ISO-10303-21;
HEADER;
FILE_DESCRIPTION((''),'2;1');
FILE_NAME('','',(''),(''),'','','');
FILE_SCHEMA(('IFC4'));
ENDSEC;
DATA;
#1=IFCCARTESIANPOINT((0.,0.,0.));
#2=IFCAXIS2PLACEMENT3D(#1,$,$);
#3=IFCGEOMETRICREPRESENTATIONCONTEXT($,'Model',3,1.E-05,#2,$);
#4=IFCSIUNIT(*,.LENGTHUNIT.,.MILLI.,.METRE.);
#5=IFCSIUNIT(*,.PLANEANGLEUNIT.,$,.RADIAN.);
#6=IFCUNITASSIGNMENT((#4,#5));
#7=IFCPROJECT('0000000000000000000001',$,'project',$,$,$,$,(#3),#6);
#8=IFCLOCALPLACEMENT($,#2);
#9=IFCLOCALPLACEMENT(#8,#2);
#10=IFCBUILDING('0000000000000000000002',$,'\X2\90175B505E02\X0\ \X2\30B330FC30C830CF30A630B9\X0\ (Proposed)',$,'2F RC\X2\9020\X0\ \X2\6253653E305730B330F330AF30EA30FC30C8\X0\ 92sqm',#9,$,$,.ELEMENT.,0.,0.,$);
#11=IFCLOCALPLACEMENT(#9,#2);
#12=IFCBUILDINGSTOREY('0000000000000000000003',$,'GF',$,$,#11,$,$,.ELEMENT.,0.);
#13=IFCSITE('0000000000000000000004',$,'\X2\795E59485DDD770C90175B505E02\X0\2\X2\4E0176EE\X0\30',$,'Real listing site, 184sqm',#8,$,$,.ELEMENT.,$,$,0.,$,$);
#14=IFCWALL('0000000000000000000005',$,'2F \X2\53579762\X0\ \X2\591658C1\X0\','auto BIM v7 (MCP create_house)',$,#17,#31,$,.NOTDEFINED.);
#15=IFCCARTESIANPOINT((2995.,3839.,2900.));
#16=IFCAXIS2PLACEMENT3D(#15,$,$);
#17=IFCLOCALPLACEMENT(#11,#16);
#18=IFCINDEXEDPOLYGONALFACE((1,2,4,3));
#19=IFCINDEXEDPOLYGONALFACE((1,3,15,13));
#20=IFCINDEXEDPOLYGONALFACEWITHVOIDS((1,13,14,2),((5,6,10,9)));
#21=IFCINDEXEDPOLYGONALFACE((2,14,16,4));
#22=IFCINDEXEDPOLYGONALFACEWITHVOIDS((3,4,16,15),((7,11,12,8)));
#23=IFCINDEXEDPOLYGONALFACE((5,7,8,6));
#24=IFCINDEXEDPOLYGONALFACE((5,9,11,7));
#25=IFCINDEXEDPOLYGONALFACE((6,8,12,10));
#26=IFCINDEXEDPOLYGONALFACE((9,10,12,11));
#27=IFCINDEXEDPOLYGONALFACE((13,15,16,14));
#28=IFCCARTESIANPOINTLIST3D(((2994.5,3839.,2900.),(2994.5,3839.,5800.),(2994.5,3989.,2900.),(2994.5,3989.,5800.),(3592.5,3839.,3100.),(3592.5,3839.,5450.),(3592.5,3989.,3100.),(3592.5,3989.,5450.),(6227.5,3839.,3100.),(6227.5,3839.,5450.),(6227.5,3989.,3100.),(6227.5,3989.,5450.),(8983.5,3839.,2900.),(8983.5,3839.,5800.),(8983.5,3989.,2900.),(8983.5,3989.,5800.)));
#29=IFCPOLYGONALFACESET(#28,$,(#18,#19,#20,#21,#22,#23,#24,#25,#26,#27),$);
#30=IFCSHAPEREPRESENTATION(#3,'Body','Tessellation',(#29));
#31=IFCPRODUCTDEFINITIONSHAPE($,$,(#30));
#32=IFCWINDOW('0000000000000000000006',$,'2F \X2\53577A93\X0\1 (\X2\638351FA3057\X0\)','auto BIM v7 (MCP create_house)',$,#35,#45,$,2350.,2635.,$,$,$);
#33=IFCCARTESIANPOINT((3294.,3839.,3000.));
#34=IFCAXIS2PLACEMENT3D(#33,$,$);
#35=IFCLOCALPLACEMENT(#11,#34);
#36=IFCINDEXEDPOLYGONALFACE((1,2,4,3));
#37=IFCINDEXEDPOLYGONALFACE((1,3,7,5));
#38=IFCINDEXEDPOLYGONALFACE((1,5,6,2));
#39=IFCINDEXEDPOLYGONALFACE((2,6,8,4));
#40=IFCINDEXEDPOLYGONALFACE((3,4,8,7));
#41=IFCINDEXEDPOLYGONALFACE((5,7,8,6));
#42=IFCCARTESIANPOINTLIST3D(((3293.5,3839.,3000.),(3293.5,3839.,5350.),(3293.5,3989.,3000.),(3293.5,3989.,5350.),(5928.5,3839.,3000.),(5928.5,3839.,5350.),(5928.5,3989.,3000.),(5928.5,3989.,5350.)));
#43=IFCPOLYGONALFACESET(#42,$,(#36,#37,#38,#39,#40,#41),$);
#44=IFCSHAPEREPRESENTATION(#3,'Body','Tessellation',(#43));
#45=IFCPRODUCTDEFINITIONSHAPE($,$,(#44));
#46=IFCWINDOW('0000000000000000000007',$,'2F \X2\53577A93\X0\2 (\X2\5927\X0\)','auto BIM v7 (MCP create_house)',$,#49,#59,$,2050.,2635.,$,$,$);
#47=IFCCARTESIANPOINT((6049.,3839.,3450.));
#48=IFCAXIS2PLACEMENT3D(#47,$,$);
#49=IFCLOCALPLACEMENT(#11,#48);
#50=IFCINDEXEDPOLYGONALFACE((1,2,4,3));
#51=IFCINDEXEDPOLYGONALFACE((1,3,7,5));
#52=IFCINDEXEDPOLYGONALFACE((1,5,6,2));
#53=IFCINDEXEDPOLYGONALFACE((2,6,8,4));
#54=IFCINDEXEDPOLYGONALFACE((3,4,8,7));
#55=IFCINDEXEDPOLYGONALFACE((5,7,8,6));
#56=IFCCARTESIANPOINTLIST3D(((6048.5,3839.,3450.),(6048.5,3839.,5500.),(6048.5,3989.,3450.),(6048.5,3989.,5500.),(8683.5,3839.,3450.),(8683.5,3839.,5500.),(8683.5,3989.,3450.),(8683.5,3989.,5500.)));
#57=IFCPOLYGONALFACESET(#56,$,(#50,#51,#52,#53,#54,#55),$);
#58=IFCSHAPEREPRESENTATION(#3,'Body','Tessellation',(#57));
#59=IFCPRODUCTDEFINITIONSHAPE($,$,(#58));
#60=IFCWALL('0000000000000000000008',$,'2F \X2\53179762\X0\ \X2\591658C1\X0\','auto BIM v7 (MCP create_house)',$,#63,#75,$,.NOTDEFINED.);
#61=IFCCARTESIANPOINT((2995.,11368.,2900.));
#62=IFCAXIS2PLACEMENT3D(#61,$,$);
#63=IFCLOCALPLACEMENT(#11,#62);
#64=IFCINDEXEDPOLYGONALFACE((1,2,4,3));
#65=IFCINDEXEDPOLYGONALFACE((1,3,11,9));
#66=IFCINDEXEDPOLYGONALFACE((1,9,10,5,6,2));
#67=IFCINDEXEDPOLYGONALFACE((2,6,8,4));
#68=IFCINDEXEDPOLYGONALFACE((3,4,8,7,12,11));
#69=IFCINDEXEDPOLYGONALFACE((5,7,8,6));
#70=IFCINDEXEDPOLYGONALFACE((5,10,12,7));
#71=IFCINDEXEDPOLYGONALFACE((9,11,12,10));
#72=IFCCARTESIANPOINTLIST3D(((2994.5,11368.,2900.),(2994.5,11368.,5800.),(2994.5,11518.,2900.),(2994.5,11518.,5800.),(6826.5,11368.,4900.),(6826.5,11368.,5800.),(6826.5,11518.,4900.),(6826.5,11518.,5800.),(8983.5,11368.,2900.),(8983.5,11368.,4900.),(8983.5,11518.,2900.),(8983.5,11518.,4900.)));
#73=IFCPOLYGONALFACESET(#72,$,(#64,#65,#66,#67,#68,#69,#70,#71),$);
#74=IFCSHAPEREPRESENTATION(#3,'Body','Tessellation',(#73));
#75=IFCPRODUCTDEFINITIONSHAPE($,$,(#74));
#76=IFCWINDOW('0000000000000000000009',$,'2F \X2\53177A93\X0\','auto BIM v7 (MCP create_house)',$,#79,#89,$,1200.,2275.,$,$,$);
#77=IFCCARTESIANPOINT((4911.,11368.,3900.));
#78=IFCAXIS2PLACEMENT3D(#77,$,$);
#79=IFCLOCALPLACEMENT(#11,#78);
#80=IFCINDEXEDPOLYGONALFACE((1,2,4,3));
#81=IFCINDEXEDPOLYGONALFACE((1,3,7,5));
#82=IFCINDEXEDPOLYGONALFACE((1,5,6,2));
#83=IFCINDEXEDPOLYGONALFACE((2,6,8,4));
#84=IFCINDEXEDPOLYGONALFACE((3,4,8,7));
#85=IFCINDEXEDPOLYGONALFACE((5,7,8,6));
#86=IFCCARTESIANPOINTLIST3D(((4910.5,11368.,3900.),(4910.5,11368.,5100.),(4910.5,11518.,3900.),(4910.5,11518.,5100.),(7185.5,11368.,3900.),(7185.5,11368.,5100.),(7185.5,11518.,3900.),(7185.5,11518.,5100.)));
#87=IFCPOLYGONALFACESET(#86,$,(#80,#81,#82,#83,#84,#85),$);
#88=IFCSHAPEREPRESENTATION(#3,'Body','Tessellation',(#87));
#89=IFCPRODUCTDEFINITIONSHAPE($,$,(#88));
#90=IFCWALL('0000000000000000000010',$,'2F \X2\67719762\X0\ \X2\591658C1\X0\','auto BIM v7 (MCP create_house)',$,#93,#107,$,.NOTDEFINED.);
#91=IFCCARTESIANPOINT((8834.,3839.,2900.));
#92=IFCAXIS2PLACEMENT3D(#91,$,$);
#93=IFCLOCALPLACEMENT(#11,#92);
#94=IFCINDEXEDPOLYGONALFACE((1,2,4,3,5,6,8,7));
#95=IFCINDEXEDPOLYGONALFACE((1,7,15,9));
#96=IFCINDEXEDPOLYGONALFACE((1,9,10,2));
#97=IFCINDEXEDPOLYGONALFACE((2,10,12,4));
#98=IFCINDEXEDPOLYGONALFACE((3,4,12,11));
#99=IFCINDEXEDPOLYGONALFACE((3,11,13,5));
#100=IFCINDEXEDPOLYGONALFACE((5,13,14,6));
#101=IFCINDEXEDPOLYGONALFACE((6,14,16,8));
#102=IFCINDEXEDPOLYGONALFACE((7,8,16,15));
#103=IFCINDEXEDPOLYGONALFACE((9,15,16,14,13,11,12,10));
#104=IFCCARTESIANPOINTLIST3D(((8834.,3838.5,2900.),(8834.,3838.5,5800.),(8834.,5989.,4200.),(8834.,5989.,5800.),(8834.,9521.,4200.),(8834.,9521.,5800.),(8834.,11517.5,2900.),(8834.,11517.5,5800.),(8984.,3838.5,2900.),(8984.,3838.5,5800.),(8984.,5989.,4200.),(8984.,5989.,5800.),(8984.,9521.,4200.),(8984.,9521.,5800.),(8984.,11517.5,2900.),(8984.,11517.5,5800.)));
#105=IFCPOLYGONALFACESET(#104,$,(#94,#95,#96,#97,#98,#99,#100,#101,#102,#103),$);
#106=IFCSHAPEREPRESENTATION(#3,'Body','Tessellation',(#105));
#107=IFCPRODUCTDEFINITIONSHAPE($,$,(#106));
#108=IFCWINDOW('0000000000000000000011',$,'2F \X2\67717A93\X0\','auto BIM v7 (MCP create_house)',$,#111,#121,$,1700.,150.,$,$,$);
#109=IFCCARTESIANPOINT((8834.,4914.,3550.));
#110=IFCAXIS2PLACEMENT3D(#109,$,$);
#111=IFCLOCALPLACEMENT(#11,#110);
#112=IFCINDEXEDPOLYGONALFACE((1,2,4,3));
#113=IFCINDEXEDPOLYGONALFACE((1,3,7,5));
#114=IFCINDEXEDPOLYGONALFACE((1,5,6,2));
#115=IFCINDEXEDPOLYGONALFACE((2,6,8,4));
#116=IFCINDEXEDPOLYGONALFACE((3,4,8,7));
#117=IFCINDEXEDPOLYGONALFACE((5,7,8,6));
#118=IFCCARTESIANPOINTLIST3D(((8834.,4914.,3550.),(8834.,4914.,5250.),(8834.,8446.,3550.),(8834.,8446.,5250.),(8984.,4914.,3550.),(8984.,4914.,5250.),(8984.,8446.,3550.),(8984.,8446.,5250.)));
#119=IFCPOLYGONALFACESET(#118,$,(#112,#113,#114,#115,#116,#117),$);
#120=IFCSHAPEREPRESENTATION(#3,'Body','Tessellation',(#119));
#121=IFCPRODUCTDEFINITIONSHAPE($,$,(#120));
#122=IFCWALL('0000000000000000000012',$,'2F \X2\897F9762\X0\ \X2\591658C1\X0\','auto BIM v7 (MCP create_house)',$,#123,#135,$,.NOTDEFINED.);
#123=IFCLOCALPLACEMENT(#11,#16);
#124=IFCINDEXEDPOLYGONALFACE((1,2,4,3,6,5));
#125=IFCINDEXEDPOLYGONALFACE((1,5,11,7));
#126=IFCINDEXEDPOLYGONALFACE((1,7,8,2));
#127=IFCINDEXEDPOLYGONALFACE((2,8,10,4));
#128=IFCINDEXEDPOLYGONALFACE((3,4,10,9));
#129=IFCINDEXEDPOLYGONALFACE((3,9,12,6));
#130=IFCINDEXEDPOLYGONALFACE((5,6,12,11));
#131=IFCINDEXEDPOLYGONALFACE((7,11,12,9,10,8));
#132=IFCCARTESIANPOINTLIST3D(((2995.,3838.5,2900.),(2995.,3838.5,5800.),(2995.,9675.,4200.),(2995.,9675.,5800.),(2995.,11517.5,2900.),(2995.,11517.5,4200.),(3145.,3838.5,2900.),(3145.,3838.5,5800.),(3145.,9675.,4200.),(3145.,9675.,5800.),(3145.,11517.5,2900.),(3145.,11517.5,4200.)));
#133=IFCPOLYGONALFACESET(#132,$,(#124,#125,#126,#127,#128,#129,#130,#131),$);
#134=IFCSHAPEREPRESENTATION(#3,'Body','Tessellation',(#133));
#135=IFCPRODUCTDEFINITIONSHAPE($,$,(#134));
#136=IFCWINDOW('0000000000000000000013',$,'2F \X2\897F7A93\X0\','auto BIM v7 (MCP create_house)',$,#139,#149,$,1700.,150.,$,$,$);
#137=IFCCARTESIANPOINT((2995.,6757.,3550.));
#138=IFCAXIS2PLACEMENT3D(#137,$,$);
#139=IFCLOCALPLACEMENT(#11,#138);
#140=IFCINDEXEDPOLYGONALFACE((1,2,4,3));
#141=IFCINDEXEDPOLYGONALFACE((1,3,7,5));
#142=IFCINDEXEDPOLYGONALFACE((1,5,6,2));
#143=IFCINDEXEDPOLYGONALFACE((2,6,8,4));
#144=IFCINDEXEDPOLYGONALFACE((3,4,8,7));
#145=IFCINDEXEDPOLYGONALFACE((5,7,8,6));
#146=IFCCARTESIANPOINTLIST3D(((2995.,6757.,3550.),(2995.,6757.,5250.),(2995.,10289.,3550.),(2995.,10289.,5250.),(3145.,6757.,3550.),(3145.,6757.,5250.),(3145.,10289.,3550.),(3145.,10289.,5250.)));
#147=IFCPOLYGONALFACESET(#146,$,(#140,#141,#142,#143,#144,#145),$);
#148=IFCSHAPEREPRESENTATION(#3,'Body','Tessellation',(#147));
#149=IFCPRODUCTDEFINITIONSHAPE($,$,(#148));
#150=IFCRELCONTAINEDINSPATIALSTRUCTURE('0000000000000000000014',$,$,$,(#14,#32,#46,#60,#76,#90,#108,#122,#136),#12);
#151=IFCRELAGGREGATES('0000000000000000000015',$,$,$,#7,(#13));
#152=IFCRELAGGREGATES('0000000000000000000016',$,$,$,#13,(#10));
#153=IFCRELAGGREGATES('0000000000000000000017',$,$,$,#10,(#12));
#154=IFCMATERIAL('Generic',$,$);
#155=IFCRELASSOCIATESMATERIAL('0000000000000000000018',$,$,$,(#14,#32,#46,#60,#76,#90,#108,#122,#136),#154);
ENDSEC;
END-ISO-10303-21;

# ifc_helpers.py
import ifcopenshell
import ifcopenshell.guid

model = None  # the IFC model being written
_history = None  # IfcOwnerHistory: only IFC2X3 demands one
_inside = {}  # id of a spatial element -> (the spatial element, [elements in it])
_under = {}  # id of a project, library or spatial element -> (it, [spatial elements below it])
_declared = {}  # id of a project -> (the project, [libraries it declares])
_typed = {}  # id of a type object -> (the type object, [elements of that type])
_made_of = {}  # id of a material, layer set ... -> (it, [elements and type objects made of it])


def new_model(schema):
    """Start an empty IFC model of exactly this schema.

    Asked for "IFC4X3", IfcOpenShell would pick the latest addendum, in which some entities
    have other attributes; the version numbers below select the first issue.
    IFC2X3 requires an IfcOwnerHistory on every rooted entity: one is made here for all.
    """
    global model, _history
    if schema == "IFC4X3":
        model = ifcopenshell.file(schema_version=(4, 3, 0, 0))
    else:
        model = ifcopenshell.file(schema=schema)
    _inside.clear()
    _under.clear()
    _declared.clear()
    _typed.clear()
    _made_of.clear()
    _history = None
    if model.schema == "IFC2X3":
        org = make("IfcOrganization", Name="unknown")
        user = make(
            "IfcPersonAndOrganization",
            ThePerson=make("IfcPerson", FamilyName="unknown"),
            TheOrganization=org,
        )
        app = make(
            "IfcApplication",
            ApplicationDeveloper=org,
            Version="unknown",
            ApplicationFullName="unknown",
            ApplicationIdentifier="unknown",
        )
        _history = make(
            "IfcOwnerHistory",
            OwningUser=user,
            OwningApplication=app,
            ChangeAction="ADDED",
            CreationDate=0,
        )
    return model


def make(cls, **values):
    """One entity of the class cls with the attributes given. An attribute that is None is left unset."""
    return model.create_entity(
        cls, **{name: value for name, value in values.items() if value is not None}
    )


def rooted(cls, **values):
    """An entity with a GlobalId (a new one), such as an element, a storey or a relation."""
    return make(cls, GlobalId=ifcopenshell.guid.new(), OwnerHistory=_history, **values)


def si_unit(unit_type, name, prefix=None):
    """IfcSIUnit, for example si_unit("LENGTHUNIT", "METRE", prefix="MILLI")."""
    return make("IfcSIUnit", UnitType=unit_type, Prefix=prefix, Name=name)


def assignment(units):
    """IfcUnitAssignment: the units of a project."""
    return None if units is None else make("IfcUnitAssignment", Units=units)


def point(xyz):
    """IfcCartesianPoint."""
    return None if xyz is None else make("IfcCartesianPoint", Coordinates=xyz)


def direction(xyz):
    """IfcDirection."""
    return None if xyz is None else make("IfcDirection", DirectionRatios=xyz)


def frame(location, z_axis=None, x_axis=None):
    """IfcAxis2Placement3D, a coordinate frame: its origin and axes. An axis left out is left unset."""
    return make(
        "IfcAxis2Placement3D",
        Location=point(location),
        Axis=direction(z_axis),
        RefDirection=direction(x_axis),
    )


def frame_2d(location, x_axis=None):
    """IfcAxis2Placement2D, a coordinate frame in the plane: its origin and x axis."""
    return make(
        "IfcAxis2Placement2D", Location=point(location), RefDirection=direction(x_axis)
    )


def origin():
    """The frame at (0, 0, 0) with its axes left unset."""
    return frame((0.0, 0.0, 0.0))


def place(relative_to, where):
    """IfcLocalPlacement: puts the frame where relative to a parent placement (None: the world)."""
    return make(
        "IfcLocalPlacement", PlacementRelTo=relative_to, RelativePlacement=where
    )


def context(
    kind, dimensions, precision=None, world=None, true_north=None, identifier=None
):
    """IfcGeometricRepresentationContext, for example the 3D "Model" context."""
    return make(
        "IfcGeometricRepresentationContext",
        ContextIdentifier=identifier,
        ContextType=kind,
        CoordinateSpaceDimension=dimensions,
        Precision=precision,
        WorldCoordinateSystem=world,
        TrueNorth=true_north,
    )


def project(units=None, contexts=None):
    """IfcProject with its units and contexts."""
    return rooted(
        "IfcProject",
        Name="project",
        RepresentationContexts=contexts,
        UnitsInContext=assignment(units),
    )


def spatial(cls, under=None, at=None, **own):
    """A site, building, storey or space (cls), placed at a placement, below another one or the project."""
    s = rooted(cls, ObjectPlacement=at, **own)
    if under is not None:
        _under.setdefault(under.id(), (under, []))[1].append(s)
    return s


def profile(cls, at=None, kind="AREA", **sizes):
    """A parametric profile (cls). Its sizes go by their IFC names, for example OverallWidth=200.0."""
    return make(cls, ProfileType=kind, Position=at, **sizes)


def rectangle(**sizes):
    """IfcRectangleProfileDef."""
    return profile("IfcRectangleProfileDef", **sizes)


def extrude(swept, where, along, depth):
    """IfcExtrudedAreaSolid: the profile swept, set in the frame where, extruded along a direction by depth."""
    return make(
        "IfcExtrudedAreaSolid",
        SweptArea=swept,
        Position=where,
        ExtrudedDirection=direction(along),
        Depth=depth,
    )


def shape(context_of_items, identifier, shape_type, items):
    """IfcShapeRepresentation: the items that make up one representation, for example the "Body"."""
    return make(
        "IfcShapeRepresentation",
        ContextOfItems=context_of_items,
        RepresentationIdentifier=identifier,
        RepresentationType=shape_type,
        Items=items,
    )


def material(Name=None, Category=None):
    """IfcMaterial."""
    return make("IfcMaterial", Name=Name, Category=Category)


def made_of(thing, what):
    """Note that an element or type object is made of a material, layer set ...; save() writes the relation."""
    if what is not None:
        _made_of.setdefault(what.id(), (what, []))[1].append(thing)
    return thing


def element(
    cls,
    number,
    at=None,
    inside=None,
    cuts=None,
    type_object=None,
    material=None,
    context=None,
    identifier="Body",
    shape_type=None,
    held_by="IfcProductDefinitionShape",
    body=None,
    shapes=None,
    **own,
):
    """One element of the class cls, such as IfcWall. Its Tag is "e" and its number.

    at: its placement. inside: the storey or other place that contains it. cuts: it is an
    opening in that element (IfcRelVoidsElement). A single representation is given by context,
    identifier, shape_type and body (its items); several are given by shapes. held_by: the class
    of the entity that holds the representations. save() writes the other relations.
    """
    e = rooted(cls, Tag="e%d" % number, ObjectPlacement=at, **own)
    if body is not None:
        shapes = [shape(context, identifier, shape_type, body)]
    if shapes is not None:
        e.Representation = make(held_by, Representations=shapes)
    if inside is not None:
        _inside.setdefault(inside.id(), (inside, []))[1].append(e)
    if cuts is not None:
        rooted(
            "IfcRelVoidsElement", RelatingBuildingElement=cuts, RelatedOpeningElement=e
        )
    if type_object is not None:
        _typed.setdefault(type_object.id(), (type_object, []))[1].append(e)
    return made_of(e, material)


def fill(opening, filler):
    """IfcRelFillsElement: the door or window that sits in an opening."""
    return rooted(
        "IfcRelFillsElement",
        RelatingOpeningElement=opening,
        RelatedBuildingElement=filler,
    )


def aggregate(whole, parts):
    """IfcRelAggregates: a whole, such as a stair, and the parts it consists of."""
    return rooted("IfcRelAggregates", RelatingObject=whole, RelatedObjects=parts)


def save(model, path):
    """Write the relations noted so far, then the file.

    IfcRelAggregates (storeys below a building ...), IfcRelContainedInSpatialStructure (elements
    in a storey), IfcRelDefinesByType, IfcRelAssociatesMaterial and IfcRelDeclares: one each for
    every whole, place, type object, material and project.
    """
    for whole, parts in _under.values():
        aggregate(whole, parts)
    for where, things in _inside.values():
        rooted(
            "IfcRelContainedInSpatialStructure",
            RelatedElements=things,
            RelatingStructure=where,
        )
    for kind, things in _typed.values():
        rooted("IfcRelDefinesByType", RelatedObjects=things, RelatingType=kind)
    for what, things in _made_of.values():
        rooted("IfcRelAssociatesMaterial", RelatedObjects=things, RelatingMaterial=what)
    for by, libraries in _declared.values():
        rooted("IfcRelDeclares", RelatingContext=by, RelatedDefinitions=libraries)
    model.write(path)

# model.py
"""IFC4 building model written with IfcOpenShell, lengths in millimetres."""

from ifc_helpers import new_model, si_unit, frame, frame_2d, origin, place, context, project, spatial, rectangle, extrude, material, element, fill, save


model = new_model("IFC4")

# Units and contexts
model_context = context("Model", 3, precision=1e-05, world=origin())
ifc_project = project(units=[si_unit("LENGTHUNIT", "METRE", prefix="MILLI"), si_unit("PLANEANGLEUNIT", "RADIAN")], contexts=[model_context])

# Site, building, storey
site_placement = place(None, origin())
site = spatial("IfcSite", under=ifc_project, at=site_placement, Name="神奈川県逗子市2丁目30", ObjectType="Real listing site, 184sqm", CompositionType="ELEMENT", RefElevation=0.0)
building_placement = place(site_placement, origin())
building = spatial("IfcBuilding", under=site, at=building_placement, Name="逗子市 コートハウス (Proposed)", ObjectType="2F RC造 打放しコンクリート 92sqm", CompositionType="ELEMENT", ElevationOfRefHeight=0.0, ElevationOfTerrain=0.0)
storey_placement = place(building_placement, origin())
storey = spatial("IfcBuildingStorey", under=building, at=storey_placement, Name="GF", CompositionType="ELEMENT", Elevation=0.0)

# Shared definitions
ifc_material = material(Name="Generic")

# Wall, openings, windows
wall_1_placement = place(storey_placement, frame((2995.0, 3839.0, 2900.0)))
wall_1 = element("IfcWall", 1, at=wall_1_placement, inside=storey, material=ifc_material, Name="2F 南面 外壁", Description="auto BIM v7 (MCP create_house)", PredefinedType="NOTDEFINED", context=model_context, shape_type="SweptSolid", body=[
    extrude(rectangle(XDim=5989.0, YDim=150.0, at=frame_2d((2994.0, 75.0))), frame((2995.0, 3839.0, 2900.0)), (0.0, 0.0, 1.0), 2900.0),
])
opening_1_placement = place(storey_placement, frame((3294.0, 3839.0, 3000.0)))
opening_1 = element("IfcOpeningElement", 2, at=opening_1_placement, cuts=wall_1, PredefinedType="NOTDEFINED", context=model_context, shape_type="SweptSolid", body=[
    extrude(rectangle(XDim=2635.0, YDim=150.0, at=frame_2d((1317.0, 75.0))), frame((3294.0, 3839.0, 3000.0)), (0.0, 0.0, 1.0), 2350.0),
])
opening_2_placement = place(storey_placement, frame((6049.0, 3839.0, 3450.0)))
opening_2 = element("IfcOpeningElement", 3, at=opening_2_placement, cuts=wall_1, PredefinedType="NOTDEFINED", context=model_context, shape_type="SweptSolid", body=[
    extrude(rectangle(XDim=2635.0, YDim=150.0, at=frame_2d((1317.0, 75.0))), frame((6049.0, 3839.0, 3450.0)), (0.0, 0.0, 1.0), 2050.0),
])
window_1_placement = place(storey_placement, frame((3294.0, 3839.0, 3000.0)))
window_1 = element("IfcWindow", 4, at=window_1_placement, inside=storey, material=ifc_material, Name="2F 南窓1 (掃出し)", Description="auto BIM v7 (MCP create_house)", OverallHeight=2350.0, OverallWidth=2635.0, context=model_context, shape_type="SweptSolid", body=[
    extrude(rectangle(XDim=2635.0, YDim=150.0, at=frame_2d((1317.0, 75.0))), frame((3294.0, 3839.0, 3000.0)), (0.0, 0.0, 1.0), 2350.0),
])
fill(opening_1, window_1)
window_2_placement = place(storey_placement, frame((6049.0, 3839.0, 3450.0)))
window_2 = element("IfcWindow", 5, at=window_2_placement, inside=storey, material=ifc_material, Name="2F 南窓2 (大)", Description="auto BIM v7 (MCP create_house)", OverallHeight=2050.0, OverallWidth=2635.0, context=model_context, shape_type="SweptSolid", body=[
    extrude(rectangle(XDim=2635.0, YDim=150.0, at=frame_2d((1317.0, 75.0))), frame((6049.0, 3839.0, 3450.0)), (0.0, 0.0, 1.0), 2050.0),
])
fill(opening_2, window_2)

# Walls, openings, windows
wall_2_placement = place(storey_placement, frame((2995.0, 11368.0, 2900.0)))
wall_2 = element("IfcWall", 6, at=wall_2_placement, inside=storey, material=ifc_material, Name="2F 北面 外壁", Description="auto BIM v7 (MCP create_house)", PredefinedType="NOTDEFINED", context=model_context, shape_type="SweptSolid", body=[
    extrude(rectangle(XDim=5989.0, YDim=150.0, at=frame_2d((2994.0, 75.0))), frame((2995.0, 11368.0, 2900.0)), (0.0, 0.0, 1.0), 2900.0),
])
opening_3_placement = place(storey_placement, frame((4911.0, 11368.0, 3900.0)))
opening_3 = element("IfcOpeningElement", 7, at=opening_3_placement, cuts=wall_2, PredefinedType="NOTDEFINED", context=model_context, shape_type="SweptSolid", body=[
    extrude(rectangle(XDim=2275.0, YDim=150.0, at=frame_2d((1137.0, 75.0))), frame((4911.0, 11368.0, 3900.0)), (0.0, 0.0, 1.0), 1200.0),
])
window_3_placement = place(storey_placement, frame((4911.0, 11368.0, 3900.0)))
window_3 = element("IfcWindow", 8, at=window_3_placement, inside=storey, material=ifc_material, Name="2F 北窓", Description="auto BIM v7 (MCP create_house)", OverallHeight=1200.0, OverallWidth=2275.0, context=model_context, shape_type="SweptSolid", body=[
    extrude(rectangle(XDim=2275.0, YDim=150.0, at=frame_2d((1137.0, 75.0))), frame((4911.0, 11368.0, 3900.0)), (0.0, 0.0, 1.0), 1200.0),
])
fill(opening_3, window_3)
wall_3_placement = place(storey_placement, frame((8834.0, 3839.0, 2900.0)))
wall_3 = element("IfcWall", 9, at=wall_3_placement, inside=storey, material=ifc_material, Name="2F 東面 外壁", Description="auto BIM v7 (MCP create_house)", PredefinedType="NOTDEFINED", context=model_context, shape_type="SweptSolid", body=[
    extrude(rectangle(XDim=150.0, YDim=7679.0, at=frame_2d((75.0, 3839.0))), frame((8834.0, 3839.0, 2900.0)), (0.0, 0.0, 1.0), 2900.0),
])
opening_4_placement = place(storey_placement, frame((8834.0, 4914.0, 3550.0)))
opening_4 = element("IfcOpeningElement", 10, at=opening_4_placement, cuts=wall_3, PredefinedType="NOTDEFINED", context=model_context, shape_type="SweptSolid", body=[
    extrude(rectangle(XDim=150.0, YDim=3532.0, at=frame_2d((75.0, 1766.0))), frame((8834.0, 4914.0, 3550.0)), (0.0, 0.0, 1.0), 1700.0),
])
window_4_placement = place(storey_placement, frame((8834.0, 4914.0, 3550.0)))
window_4 = element("IfcWindow", 11, at=window_4_placement, inside=storey, material=ifc_material, Name="2F 東窓", Description="auto BIM v7 (MCP create_house)", OverallHeight=1700.0, OverallWidth=150.0, context=model_context, shape_type="SweptSolid", body=[
    extrude(rectangle(XDim=150.0, YDim=3532.0, at=frame_2d((75.0, 1766.0))), frame((8834.0, 4914.0, 3550.0)), (0.0, 0.0, 1.0), 1700.0),
])
fill(opening_4, window_4)
wall_4_placement = place(storey_placement, frame((2995.0, 3839.0, 2900.0)))
wall_4 = element("IfcWall", 12, at=wall_4_placement, inside=storey, material=ifc_material, Name="2F 西面 外壁", Description="auto BIM v7 (MCP create_house)", PredefinedType="NOTDEFINED", context=model_context, shape_type="SweptSolid", body=[
    extrude(rectangle(XDim=150.0, YDim=7679.0, at=frame_2d((75.0, 3839.0))), frame((2995.0, 3839.0, 2900.0)), (0.0, 0.0, 1.0), 2900.0),
])
opening_5_placement = place(storey_placement, frame((2995.0, 6757.0, 3550.0)))
opening_5 = element("IfcOpeningElement", 13, at=opening_5_placement, cuts=wall_4, PredefinedType="NOTDEFINED", context=model_context, shape_type="SweptSolid", body=[
    extrude(rectangle(XDim=150.0, YDim=3532.0, at=frame_2d((75.0, 1766.0))), frame((2995.0, 6757.0, 3550.0)), (0.0, 0.0, 1.0), 1700.0),
])
window_5_placement = place(storey_placement, frame((2995.0, 6757.0, 3550.0)))
window_5 = element("IfcWindow", 14, at=window_5_placement, inside=storey, material=ifc_material, Name="2F 西窓", Description="auto BIM v7 (MCP create_house)", OverallHeight=1700.0, OverallWidth=150.0, context=model_context, shape_type="SweptSolid", body=[
    extrude(rectangle(XDim=150.0, YDim=3532.0, at=frame_2d((75.0, 1766.0))), frame((2995.0, 6757.0, 3550.0)), (0.0, 0.0, 1.0), 1700.0),
])
fill(opening_5, window_5)

save(model, "model.ifc")
